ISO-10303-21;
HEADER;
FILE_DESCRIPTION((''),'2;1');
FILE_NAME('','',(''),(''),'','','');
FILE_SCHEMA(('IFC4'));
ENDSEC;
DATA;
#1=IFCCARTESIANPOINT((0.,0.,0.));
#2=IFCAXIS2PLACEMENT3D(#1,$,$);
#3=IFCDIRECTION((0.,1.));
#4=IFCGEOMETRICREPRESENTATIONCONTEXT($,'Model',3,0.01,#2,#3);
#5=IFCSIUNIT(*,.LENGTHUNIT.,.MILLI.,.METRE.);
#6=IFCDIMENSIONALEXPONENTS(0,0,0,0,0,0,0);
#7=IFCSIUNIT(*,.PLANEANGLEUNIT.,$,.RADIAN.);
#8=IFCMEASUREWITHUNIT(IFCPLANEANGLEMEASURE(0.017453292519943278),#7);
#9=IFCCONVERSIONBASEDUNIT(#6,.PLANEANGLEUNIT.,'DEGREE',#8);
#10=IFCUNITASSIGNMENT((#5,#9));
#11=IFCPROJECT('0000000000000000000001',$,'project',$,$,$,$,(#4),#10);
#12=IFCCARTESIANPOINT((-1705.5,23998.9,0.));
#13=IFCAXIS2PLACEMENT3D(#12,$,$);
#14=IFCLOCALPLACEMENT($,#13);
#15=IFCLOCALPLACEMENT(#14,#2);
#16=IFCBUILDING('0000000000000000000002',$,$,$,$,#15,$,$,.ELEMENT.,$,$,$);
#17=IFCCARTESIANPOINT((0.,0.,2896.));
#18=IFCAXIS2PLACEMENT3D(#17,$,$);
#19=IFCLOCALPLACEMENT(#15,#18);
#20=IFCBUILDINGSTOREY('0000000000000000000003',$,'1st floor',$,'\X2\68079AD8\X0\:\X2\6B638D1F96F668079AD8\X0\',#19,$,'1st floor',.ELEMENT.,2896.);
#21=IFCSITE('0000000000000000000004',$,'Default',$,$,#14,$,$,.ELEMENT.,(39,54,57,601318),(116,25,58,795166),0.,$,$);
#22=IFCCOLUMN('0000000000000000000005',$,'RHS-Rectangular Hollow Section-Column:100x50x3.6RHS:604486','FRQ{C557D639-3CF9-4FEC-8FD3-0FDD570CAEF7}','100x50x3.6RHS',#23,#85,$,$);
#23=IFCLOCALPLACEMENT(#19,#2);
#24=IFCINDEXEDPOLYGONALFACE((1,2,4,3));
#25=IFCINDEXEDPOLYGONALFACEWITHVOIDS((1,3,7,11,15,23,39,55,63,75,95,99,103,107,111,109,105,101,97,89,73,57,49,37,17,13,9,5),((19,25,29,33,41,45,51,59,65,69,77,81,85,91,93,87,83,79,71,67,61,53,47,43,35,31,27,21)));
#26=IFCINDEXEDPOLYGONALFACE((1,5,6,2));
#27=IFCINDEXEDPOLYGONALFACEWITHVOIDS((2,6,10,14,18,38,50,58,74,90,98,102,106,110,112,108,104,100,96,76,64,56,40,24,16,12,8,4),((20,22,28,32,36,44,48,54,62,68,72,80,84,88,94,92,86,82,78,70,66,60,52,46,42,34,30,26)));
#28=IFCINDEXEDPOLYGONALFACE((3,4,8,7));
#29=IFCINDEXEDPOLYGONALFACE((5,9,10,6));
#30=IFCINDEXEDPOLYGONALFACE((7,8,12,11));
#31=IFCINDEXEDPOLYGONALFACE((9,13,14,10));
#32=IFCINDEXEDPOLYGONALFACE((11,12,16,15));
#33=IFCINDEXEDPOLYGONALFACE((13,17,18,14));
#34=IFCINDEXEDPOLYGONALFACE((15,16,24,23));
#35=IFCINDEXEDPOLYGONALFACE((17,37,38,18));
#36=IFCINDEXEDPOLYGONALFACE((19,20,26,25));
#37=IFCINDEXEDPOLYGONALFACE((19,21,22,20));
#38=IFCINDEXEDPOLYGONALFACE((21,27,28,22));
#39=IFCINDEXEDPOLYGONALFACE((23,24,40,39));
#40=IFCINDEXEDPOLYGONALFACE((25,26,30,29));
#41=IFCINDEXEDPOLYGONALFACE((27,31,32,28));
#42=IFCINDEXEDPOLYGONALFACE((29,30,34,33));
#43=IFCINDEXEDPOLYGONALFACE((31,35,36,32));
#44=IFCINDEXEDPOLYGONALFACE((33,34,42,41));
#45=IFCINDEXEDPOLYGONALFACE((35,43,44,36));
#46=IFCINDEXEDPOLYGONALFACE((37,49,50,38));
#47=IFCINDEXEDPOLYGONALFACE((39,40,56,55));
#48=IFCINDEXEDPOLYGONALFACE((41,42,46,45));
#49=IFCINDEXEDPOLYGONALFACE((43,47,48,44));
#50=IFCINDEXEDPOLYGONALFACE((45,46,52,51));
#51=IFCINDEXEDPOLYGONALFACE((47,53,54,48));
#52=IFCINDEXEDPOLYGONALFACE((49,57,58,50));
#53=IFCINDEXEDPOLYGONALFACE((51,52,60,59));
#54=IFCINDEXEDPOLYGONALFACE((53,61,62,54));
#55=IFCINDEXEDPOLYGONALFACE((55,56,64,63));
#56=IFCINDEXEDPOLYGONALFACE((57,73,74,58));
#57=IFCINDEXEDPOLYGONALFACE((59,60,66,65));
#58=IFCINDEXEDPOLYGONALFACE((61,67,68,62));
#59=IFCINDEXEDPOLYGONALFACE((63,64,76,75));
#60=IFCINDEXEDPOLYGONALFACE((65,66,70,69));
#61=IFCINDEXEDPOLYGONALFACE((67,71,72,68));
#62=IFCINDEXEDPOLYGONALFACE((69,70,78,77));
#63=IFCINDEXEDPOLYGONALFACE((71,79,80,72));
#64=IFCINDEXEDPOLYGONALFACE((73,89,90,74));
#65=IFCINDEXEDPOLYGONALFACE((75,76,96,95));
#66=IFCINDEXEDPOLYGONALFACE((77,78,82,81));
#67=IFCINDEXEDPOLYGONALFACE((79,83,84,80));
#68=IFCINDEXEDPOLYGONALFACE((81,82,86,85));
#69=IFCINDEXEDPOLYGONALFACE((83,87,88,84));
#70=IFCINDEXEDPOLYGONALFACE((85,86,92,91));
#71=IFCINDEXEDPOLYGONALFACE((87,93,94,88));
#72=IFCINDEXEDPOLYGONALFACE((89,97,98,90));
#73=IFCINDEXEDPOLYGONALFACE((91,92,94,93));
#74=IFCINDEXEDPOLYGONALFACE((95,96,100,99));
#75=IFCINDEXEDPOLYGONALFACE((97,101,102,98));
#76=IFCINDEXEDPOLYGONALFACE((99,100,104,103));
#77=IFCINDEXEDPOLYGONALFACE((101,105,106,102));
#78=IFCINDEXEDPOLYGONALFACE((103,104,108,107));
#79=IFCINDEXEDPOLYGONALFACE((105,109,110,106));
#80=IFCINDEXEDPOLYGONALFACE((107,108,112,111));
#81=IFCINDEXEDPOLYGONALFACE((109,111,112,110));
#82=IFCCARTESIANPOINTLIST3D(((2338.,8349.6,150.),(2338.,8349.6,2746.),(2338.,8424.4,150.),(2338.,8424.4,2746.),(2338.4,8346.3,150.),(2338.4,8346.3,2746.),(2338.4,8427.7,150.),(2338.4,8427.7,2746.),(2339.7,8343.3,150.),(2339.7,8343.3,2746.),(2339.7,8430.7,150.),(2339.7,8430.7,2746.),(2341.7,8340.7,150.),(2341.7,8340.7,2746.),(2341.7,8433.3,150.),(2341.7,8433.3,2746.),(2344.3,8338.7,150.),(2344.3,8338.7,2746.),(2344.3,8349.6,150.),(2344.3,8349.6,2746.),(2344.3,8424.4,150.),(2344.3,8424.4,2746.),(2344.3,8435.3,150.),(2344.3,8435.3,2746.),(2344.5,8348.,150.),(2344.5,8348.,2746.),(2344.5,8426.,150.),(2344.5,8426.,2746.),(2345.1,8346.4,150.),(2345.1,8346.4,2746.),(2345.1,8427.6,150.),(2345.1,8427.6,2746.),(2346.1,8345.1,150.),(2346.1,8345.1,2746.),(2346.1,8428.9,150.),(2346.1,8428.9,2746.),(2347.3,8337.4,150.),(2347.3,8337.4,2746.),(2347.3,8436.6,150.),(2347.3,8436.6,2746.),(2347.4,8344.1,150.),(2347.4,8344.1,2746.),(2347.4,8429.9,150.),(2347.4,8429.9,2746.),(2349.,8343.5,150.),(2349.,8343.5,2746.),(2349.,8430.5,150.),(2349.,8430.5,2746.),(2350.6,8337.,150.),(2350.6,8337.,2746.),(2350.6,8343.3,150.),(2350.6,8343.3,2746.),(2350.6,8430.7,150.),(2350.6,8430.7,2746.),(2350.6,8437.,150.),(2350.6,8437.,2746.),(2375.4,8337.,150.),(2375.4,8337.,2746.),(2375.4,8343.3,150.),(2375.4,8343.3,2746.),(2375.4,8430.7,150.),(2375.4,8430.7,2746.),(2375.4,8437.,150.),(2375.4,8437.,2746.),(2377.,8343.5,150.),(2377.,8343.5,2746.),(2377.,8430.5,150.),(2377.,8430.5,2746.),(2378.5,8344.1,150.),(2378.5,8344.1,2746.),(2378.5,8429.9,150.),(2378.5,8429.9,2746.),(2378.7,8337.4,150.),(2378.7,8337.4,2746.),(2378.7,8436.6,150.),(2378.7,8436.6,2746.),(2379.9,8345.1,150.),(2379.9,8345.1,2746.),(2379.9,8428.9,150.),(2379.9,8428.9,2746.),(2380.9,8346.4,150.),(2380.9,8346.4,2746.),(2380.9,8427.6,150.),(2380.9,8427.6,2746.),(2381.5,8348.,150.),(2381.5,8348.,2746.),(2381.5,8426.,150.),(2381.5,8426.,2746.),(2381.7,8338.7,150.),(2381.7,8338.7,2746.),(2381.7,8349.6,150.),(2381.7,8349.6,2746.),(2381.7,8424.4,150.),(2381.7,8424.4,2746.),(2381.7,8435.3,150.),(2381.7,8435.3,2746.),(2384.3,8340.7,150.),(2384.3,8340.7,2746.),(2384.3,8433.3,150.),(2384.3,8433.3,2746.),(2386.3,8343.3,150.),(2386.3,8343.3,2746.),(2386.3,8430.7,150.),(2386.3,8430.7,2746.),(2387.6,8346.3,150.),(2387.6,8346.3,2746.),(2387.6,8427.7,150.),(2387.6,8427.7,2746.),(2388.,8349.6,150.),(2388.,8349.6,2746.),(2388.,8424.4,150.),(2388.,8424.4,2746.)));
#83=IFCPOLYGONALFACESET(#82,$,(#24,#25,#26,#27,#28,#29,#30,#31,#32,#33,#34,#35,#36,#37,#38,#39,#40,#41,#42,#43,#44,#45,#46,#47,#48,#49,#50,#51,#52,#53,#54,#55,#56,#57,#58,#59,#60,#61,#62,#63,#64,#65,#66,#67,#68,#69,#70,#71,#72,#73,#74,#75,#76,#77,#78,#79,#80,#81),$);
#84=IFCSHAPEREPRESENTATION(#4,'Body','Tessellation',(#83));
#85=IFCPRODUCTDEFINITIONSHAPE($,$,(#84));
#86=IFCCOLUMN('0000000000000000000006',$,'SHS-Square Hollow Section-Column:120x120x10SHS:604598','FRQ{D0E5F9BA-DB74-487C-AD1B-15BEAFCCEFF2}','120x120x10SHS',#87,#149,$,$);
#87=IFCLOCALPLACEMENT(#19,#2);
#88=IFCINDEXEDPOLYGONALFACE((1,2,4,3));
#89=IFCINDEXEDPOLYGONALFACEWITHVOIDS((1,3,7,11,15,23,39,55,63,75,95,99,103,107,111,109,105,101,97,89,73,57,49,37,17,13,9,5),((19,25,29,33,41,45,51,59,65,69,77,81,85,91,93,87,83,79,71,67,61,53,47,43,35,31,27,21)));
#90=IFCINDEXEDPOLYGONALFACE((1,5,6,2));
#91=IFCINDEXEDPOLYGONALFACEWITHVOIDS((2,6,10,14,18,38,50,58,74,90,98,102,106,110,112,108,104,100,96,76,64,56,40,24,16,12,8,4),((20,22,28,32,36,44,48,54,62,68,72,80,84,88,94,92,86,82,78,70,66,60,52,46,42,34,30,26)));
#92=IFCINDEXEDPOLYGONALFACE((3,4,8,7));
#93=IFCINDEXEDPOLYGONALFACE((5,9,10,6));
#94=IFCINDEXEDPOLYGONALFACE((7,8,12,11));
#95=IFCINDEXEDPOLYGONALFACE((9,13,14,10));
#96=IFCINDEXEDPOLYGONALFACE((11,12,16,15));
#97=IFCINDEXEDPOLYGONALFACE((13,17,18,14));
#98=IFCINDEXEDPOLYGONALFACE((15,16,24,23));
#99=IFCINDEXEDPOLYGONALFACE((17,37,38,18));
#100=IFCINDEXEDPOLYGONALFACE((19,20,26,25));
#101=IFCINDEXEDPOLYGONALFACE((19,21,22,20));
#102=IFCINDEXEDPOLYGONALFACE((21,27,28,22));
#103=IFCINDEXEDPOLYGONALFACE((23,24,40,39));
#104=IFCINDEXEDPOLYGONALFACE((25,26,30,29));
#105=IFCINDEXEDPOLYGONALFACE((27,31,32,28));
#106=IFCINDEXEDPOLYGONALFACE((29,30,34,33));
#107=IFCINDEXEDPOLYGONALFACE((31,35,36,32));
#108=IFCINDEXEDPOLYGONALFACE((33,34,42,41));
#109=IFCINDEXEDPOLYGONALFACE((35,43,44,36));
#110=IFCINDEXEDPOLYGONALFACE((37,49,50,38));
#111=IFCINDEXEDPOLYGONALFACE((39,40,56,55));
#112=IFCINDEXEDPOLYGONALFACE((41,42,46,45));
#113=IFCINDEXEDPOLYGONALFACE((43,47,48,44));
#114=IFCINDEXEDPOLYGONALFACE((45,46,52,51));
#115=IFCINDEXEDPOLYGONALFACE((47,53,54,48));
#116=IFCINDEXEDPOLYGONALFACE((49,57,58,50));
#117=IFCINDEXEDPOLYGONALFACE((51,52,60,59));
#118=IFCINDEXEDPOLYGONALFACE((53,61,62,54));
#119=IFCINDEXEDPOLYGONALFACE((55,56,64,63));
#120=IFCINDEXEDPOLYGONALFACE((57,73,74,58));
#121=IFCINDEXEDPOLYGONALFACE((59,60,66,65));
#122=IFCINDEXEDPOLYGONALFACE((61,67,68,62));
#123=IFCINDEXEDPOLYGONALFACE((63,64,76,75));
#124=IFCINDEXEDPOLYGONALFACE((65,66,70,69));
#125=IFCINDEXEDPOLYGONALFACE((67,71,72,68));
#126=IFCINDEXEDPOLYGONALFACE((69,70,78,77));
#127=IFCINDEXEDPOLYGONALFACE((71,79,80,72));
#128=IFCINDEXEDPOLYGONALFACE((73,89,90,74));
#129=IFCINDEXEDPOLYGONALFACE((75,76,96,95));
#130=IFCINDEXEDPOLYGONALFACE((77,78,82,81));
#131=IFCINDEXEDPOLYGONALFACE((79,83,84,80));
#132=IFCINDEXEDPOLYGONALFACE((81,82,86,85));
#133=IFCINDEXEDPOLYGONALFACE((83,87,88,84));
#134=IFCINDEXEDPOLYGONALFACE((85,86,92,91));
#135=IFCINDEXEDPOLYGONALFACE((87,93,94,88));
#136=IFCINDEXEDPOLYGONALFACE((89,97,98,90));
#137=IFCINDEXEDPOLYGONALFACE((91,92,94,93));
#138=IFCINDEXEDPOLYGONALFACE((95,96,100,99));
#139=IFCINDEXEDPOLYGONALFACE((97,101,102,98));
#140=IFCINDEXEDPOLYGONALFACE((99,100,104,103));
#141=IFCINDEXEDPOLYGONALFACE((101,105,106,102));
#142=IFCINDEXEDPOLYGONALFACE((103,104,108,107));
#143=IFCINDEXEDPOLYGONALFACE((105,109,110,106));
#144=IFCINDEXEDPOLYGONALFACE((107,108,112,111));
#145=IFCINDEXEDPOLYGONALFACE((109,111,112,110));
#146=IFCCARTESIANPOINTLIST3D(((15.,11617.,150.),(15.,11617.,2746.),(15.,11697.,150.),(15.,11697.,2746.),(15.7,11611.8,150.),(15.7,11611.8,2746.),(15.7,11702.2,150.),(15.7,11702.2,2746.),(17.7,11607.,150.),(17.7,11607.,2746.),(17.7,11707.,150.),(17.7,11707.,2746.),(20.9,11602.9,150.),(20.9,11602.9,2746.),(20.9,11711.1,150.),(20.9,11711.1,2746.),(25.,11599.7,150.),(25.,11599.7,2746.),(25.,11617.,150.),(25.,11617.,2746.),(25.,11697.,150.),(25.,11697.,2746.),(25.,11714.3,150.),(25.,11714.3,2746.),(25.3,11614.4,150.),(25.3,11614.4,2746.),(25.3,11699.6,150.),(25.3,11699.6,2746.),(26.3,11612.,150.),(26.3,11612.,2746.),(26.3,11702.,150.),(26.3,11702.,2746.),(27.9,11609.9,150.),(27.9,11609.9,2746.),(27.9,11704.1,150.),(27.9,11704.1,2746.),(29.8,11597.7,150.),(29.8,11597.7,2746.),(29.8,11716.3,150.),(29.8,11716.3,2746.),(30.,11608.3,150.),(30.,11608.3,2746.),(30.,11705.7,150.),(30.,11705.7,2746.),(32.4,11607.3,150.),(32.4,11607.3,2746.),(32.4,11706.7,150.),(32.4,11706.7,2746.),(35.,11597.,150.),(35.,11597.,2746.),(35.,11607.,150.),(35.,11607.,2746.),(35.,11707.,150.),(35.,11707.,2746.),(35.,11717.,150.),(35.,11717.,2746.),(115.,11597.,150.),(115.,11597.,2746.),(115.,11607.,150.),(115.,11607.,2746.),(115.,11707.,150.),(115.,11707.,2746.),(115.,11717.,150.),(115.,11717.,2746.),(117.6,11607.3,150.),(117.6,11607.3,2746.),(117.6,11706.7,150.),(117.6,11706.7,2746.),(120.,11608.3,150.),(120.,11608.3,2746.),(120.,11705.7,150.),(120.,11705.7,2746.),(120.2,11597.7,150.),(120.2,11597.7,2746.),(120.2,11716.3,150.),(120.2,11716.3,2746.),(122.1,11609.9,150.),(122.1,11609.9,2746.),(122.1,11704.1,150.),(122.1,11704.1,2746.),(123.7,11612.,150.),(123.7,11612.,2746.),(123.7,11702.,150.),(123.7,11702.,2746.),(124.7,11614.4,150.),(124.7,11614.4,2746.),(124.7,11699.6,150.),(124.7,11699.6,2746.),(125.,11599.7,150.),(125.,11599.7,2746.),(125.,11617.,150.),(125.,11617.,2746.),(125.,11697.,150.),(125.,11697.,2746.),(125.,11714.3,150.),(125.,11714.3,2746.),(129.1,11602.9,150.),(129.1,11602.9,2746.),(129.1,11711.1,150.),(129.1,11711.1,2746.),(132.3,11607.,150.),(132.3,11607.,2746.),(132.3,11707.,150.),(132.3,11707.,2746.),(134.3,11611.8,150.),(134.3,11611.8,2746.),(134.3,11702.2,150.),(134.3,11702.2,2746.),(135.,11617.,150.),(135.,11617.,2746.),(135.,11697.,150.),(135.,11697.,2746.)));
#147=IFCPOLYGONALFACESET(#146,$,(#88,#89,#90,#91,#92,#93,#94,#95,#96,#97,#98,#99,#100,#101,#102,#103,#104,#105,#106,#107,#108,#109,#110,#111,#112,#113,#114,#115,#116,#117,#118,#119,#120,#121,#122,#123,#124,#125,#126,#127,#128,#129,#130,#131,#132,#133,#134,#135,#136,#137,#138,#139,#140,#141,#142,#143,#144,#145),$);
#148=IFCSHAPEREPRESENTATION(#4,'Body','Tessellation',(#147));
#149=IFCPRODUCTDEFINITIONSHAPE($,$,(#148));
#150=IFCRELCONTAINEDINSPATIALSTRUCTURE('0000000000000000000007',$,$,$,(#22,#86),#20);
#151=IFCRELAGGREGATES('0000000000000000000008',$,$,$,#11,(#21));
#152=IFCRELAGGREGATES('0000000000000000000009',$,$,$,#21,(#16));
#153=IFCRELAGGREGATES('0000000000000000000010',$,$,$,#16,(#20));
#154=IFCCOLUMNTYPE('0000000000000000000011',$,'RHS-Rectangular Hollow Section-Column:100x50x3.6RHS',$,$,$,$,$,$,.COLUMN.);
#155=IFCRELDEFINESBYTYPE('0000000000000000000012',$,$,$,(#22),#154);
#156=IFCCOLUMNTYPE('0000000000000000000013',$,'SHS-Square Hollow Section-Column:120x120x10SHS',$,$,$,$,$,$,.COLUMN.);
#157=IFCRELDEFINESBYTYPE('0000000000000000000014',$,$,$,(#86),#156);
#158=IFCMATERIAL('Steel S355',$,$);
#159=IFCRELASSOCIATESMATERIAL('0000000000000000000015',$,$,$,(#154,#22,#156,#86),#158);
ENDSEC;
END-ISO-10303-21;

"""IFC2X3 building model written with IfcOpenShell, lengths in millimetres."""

from ifc_helpers import new_model, entity, si_unit, converted_unit, direction, frame, origin, origin_2d, place, context, project, spatial, hollow_rectangle, extrude, clip, halfspace, material, type_object, element, save


model = new_model("IFC2X3")

# Units and contexts
model_context = context("Model", 3, precision=0.01, world=origin(), true_north=direction((0.0, 1.0)))
ifc_project = project(units=[si_unit("LENGTHUNIT", "METRE", prefix="MILLI"), converted_unit("PLANEANGLEUNIT", "DEGREE", entity("IfcPlaneAngleMeasure", 0.017453292519943278), si_unit("PLANEANGLEUNIT", "RADIAN"), dimensions=[0, 0, 0, 0, 0, 0, 0])], contexts=[model_context])

# Site, building, storey
site_placement = place(None, frame((-1705.5, 23998.9, 0.0)))
site = spatial("IfcSite", under=ifc_project, at=site_placement, Name="Default", CompositionType="ELEMENT", RefLatitude=(39, 54, 57, 601318), RefLongitude=(116, 25, 58, 795166), RefElevation=0.0)
building_placement = place(site_placement, origin())
building = spatial("IfcBuilding", under=site, at=building_placement, CompositionType="ELEMENT")
storey_placement = place(building_placement, frame((0.0, 0.0, 2896.0)))
storey = spatial("IfcBuildingStorey", under=building, at=storey_placement, Name="1st floor", ObjectType="标高:正负零标高", LongName="1st floor", CompositionType="ELEMENT", Elevation=2896.0)

# Columns
ifc_material_1 = material(Name="Steel S355")
column_type_1 = type_object("IfcColumnType", Name="RHS-Rectangular Hollow Section-Column:100x50x3.6RHS", PredefinedType="COLUMN", material=ifc_material_1)
column_1_placement = place(storey_placement, frame((2363.0, 8387.0, 2746.0), z_axis=(0.0, 0.0, 1.0), x_axis=(-1.0, 0.0, 0.0)))
element("IfcColumn", 1, at=column_1_placement, inside=storey, type_object=column_type_1, material=ifc_material_1, Name="RHS-Rectangular Hollow Section-Column:100x50x3.6RHS:604486", Description="FRQ{C557D639-3CF9-4FEC-8FD3-0FDD570CAEF7}", ObjectType="100x50x3.6RHS", context=model_context, shape_type="Clipping", body=[
    clip(extrude(hollow_rectangle(XDim=50.0, YDim=100.0, WallThickness=6.3, InnerFilletRadius=6.3, OuterFilletRadius=12.6, at=origin_2d()), origin(), (0.0, 0.0, -1.0), 2651.9), halfspace(frame((2363.0, 8387.0, -2596.0), z_axis=(0.0, 0.0, 1.0), x_axis=(-1.0, 0.0, 0.0)), True)),
])
column_type_2 = type_object("IfcColumnType", Name="SHS-Square Hollow Section-Column:120x120x10SHS", PredefinedType="COLUMN", material=ifc_material_1)
column_2_placement = place(storey_placement, frame((75.0, 11657.0, 2830.9), z_axis=(0.0, 0.0, 1.0), x_axis=(0.0, -1.0, 0.0)))
element("IfcColumn", 2, at=column_2_placement, inside=storey, type_object=column_type_2, material=ifc_material_1, Name="SHS-Square Hollow Section-Column:120x120x10SHS:604598", Description="FRQ{D0E5F9BA-DB74-487C-AD1B-15BEAFCCEFF2}", ObjectType="120x120x10SHS", context=model_context, shape_type="Clipping", body=[
    clip(clip(extrude(hollow_rectangle(XDim=120.0, YDim=120.0, WallThickness=10.0, InnerFilletRadius=10.0, OuterFilletRadius=20.0, at=origin_2d()), origin(), (0.0, 0.0, -1.0), 2765.7), halfspace(frame((11657.0, -75.0, -84.9), z_axis=(0.0, 0.0, -1.0), x_axis=(0.0, -1.0, 0.0)), True)), halfspace(frame((11657.0, -75.0, -2680.9), z_axis=(0.0, 0.0, 1.0), x_axis=(0.0, 1.0, 0.0)), True)),
])

save(model, "model.ifc")
